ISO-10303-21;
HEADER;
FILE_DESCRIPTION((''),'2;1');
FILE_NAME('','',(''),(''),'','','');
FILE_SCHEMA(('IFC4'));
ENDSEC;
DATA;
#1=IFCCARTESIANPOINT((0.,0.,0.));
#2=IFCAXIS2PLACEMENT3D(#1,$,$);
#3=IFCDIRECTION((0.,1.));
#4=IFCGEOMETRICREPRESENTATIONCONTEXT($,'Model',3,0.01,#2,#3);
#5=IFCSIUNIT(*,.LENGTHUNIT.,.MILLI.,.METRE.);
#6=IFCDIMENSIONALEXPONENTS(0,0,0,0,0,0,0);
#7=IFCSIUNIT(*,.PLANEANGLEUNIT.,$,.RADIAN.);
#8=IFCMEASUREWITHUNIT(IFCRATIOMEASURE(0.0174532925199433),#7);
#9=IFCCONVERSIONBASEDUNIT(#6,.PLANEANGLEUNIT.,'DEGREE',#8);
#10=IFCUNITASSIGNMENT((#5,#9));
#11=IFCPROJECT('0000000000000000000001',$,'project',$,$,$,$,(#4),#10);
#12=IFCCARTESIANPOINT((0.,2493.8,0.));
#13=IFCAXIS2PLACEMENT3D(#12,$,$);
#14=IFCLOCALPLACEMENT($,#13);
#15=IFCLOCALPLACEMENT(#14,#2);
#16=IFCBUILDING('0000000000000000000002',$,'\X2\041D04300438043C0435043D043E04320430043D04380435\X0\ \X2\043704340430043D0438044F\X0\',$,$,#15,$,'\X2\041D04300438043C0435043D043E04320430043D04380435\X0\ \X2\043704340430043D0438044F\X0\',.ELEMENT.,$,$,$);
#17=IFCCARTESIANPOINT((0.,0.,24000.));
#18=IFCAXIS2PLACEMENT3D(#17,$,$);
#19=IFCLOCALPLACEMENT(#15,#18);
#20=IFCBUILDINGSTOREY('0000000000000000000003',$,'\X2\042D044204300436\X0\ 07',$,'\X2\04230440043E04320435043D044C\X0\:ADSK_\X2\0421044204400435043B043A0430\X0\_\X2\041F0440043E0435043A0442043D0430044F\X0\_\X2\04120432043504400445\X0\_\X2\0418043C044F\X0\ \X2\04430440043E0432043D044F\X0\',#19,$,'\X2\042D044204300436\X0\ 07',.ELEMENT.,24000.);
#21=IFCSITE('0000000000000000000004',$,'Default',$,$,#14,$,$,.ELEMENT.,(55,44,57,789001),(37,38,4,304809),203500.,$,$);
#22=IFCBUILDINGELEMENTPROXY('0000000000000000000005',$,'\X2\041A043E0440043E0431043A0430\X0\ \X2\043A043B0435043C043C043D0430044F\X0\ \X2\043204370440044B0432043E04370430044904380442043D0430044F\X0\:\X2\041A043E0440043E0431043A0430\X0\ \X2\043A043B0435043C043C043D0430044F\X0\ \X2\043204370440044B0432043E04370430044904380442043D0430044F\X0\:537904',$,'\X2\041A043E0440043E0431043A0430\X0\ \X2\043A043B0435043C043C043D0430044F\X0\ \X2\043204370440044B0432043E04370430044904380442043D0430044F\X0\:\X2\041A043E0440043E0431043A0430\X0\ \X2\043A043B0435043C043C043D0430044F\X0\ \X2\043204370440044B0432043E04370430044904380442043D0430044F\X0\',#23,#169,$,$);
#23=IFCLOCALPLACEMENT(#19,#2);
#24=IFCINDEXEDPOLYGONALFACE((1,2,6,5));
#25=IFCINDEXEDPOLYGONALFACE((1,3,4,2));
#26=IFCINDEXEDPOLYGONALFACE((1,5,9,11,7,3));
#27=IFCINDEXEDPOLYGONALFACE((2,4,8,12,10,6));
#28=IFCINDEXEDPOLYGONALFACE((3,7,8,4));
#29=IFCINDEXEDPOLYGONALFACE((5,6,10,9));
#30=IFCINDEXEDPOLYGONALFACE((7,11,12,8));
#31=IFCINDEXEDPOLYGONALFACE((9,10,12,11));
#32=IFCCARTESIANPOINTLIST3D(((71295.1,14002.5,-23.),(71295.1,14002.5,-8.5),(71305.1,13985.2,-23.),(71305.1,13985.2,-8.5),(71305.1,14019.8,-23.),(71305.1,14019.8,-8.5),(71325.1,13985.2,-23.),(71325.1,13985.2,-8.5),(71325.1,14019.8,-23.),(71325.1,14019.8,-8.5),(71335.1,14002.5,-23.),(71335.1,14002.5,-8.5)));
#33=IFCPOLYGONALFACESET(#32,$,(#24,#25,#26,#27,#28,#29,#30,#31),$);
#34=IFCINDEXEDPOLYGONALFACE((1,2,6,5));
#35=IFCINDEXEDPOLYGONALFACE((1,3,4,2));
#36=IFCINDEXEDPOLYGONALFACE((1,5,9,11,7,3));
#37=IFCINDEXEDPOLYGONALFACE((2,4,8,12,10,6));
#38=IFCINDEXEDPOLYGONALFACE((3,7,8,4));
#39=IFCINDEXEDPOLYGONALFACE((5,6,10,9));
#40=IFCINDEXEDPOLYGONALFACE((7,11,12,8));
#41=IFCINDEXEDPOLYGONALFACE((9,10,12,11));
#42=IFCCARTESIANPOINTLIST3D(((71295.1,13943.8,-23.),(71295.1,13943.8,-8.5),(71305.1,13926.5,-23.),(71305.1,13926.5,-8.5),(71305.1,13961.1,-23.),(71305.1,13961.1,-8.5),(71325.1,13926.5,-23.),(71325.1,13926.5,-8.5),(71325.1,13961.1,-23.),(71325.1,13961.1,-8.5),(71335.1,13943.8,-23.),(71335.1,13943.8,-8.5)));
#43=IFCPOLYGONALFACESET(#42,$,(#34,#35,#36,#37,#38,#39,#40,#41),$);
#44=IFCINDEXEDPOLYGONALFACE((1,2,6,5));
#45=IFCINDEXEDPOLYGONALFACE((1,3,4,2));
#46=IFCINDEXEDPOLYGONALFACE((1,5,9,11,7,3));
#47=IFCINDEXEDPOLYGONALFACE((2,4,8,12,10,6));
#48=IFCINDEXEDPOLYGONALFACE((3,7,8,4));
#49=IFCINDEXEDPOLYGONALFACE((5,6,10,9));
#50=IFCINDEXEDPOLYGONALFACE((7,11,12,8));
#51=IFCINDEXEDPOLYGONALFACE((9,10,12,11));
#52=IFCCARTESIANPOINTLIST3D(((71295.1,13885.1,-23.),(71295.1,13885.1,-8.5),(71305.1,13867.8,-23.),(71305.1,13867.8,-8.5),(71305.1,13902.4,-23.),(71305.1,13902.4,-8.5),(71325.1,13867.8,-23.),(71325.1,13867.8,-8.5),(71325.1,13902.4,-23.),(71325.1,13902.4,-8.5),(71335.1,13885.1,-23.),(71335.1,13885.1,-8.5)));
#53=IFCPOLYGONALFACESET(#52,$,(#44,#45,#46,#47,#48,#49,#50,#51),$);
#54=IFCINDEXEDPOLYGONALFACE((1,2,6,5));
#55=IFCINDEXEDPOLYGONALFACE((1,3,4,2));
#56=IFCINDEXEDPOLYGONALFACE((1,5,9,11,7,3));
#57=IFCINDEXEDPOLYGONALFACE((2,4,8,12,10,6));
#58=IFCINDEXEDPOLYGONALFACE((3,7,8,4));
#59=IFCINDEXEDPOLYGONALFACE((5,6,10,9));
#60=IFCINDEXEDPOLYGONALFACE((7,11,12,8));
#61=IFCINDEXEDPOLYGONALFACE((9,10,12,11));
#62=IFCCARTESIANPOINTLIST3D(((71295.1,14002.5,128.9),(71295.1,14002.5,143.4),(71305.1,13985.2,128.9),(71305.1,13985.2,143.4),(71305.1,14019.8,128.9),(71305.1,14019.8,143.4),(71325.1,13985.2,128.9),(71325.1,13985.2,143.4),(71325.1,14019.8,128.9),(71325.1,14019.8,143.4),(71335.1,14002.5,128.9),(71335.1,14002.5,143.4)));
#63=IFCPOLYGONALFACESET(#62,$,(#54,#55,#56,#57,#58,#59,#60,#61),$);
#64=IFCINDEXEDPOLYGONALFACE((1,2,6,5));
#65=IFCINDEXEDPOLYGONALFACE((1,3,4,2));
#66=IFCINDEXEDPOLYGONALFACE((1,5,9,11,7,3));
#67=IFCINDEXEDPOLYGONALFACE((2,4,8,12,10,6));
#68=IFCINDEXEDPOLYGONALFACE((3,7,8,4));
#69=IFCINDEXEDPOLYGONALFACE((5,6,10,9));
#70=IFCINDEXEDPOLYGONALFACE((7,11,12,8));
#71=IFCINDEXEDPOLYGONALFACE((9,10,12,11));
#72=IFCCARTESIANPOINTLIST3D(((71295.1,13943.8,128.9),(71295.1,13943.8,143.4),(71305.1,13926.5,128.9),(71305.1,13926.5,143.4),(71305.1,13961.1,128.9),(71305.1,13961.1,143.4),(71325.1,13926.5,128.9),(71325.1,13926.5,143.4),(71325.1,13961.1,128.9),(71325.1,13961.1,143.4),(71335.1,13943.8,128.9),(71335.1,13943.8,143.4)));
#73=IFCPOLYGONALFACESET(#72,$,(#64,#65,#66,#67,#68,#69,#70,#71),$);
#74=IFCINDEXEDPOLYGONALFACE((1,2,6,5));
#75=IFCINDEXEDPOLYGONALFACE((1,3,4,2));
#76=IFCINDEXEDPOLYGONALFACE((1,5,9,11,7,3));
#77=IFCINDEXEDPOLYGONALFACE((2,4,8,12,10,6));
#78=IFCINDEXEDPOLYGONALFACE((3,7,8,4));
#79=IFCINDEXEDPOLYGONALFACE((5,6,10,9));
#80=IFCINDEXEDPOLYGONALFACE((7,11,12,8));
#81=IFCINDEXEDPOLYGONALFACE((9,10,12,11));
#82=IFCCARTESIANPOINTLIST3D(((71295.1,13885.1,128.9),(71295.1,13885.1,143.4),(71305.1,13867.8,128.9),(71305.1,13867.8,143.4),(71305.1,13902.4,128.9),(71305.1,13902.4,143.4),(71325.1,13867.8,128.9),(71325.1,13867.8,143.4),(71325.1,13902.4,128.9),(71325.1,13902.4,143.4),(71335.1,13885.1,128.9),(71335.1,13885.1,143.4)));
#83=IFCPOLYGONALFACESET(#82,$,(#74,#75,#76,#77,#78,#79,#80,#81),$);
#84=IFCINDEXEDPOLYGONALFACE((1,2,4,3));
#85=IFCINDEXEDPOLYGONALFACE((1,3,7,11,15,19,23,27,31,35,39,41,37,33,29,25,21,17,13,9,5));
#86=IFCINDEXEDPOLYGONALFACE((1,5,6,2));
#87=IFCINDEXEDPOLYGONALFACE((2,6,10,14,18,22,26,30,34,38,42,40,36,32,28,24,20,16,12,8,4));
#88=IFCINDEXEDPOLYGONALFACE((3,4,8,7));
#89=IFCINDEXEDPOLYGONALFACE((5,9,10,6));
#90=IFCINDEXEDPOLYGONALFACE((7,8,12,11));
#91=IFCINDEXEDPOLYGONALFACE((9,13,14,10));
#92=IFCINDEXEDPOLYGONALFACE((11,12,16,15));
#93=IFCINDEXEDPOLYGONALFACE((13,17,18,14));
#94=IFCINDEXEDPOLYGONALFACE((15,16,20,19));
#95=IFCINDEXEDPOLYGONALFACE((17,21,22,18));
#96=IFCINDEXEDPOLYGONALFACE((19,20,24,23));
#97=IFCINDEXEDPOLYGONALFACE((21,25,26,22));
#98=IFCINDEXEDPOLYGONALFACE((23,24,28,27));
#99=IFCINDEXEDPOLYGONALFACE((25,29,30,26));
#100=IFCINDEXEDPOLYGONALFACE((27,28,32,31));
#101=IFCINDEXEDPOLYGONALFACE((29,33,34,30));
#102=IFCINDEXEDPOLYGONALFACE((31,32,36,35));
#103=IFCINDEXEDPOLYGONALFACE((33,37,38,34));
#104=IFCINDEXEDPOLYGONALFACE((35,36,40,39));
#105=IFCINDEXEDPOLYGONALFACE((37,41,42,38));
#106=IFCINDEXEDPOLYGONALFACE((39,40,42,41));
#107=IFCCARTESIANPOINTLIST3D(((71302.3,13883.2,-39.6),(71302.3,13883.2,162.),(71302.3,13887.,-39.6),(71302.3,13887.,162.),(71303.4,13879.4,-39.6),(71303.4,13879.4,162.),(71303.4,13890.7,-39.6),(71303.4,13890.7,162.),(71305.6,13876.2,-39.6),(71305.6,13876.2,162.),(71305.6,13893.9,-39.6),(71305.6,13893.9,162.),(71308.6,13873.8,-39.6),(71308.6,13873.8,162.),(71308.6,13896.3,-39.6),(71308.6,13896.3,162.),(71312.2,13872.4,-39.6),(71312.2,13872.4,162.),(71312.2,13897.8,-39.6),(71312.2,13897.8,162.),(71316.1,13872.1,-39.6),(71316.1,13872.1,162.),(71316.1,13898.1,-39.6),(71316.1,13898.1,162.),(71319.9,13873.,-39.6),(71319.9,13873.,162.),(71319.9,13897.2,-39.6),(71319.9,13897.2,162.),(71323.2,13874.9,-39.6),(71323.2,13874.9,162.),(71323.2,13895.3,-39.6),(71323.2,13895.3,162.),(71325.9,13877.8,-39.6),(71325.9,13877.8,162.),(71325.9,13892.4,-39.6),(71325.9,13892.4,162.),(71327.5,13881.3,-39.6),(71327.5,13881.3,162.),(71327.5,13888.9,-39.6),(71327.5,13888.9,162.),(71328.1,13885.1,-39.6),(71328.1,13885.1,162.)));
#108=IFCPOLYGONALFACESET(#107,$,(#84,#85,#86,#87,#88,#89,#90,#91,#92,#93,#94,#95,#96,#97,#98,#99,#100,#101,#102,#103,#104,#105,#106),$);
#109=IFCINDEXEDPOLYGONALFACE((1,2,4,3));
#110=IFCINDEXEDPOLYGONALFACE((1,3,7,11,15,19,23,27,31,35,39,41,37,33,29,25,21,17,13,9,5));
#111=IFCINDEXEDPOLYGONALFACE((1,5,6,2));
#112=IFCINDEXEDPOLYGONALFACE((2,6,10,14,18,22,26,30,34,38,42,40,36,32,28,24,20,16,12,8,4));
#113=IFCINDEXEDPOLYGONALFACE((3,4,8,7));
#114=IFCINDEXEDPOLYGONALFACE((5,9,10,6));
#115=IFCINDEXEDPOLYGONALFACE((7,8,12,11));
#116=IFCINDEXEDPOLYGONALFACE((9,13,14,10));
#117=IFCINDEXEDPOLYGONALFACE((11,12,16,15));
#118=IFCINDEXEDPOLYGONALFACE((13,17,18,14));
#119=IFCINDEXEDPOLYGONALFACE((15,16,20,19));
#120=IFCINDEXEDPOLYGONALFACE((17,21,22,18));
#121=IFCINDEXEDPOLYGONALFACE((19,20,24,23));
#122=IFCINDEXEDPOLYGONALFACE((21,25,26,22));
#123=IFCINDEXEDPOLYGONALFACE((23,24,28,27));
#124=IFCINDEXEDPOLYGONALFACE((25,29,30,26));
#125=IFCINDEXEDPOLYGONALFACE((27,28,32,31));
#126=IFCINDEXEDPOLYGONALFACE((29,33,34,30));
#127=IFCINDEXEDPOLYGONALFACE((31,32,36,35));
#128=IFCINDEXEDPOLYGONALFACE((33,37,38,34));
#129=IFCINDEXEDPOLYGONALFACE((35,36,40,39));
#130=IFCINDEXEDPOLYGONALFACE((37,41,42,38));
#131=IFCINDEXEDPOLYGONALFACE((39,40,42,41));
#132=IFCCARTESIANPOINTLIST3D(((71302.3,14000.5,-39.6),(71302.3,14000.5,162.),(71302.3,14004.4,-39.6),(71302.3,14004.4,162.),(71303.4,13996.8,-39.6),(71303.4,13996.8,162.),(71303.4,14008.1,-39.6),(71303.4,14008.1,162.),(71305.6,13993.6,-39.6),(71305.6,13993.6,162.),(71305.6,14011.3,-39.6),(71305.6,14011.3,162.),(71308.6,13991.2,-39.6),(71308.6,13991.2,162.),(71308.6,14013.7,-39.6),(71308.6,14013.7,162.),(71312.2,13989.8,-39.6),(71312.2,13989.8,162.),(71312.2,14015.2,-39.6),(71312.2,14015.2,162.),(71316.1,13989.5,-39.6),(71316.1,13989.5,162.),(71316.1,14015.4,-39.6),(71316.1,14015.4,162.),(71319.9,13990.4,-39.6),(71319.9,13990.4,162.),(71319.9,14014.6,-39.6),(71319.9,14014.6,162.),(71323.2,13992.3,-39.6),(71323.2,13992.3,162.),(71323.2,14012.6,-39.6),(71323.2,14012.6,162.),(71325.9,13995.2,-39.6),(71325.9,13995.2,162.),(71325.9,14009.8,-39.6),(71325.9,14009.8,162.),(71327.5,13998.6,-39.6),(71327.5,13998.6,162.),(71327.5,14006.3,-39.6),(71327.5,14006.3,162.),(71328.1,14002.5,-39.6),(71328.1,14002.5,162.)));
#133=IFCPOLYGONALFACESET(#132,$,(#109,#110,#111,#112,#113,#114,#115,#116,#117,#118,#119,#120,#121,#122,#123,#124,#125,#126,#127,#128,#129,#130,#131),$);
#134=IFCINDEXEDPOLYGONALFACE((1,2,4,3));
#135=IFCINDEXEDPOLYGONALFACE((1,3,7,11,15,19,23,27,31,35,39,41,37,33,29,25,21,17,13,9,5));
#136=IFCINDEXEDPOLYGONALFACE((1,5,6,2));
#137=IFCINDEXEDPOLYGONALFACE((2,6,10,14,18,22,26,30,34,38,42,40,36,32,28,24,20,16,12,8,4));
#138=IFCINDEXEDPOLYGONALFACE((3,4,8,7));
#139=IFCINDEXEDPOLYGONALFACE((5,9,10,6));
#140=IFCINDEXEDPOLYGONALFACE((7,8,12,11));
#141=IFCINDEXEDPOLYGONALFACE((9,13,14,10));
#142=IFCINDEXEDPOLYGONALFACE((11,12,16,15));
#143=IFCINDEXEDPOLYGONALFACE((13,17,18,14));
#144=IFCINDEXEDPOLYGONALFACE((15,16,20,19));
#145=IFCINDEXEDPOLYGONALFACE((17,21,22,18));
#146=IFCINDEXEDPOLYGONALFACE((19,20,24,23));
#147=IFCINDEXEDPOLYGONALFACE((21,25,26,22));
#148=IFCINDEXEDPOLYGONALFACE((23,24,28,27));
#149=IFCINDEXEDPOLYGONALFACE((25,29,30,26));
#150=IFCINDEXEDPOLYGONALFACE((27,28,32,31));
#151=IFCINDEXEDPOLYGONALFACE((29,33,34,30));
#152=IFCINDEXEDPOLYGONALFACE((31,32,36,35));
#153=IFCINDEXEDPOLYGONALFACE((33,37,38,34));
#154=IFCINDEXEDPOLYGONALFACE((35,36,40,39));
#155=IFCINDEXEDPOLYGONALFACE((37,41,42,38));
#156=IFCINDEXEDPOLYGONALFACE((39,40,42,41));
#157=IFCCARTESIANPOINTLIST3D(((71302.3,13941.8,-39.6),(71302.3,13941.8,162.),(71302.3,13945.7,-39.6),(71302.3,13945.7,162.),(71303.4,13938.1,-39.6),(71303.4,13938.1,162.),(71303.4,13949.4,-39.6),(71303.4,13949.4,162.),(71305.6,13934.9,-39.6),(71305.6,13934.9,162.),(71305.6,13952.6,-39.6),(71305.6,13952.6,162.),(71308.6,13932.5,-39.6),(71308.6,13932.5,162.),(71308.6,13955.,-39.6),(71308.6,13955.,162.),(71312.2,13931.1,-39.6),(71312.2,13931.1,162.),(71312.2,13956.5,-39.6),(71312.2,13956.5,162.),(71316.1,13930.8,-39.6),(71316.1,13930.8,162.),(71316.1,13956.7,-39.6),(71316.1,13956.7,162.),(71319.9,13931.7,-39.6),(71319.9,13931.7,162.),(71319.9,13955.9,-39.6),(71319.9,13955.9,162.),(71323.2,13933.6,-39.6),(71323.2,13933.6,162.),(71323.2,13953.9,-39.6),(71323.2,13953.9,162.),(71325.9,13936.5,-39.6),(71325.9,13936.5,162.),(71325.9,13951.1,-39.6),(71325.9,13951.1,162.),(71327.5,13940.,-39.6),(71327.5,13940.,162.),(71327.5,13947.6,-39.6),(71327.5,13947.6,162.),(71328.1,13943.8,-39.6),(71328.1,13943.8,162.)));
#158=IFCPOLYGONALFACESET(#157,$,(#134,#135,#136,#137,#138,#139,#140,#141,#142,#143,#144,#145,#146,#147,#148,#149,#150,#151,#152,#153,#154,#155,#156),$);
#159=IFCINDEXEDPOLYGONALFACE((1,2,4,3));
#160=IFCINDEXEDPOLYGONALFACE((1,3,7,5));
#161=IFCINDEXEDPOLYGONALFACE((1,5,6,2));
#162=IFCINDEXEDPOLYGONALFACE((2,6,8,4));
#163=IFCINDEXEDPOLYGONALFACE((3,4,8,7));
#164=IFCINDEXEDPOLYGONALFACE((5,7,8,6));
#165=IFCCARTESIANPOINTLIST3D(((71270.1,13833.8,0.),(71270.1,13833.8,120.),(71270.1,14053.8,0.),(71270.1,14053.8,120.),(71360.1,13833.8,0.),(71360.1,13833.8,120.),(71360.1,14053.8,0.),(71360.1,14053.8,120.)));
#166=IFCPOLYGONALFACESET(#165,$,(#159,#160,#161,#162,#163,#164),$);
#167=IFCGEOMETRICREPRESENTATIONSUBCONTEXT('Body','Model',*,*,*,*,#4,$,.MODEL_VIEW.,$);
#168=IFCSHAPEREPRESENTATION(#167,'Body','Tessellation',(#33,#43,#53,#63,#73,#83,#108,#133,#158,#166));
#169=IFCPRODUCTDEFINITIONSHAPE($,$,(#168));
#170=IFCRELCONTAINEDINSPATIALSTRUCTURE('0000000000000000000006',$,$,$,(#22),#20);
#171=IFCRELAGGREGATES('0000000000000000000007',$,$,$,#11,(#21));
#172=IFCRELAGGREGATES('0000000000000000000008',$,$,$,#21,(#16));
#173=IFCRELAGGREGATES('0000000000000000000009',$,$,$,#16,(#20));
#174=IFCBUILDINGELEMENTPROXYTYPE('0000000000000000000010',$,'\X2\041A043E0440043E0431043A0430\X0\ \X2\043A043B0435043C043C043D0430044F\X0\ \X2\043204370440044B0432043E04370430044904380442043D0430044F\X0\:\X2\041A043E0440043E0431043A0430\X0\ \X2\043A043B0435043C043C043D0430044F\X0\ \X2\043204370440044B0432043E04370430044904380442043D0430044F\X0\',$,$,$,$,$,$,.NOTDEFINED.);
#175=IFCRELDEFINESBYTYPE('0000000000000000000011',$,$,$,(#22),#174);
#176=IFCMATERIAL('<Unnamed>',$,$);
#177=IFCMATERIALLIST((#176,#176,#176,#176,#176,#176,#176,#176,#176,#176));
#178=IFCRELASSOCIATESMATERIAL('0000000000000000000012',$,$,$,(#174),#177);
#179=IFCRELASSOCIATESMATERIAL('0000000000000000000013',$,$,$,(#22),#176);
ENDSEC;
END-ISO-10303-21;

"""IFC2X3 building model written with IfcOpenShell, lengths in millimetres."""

from ifc_helpers import new_model, entity, si_unit, converted_unit, direction, frame, frame_2d, origin, place, context, subcontext, project, spatial, polyline, rectangle, circle, outline, extrude, source, transform, mapped, material, material_list, type_object, type_shapes, element, save


model = new_model("IFC2X3")

# Units and contexts
model_context = context("Model", 3, precision=0.01, world=origin(), true_north=direction((0.0, 1.0)))
body_context = subcontext(model_context, "Body", "Model", "MODEL_VIEW")
ifc_project = project(units=[si_unit("LENGTHUNIT", "METRE", prefix="MILLI"), converted_unit("PLANEANGLEUNIT", "DEGREE", entity("IfcRatioMeasure", 0.0174532925199433), si_unit("PLANEANGLEUNIT", "RADIAN"), dimensions=[0, 0, 0, 0, 0, 0, 0])], contexts=[model_context])

# Site, building, storey
site_placement = place(None, frame((0.0, 2493.8, 0.0)))
site = spatial("IfcSite", under=ifc_project, at=site_placement, Name="Default", CompositionType="ELEMENT", RefLatitude=(55, 44, 57, 789001), RefLongitude=(37, 38, 4, 304809), RefElevation=203500.0)
building_placement = place(site_placement, origin())
building = spatial("IfcBuilding", under=site, at=building_placement, Name="Наименование здания", LongName="Наименование здания", CompositionType="ELEMENT")
storey_placement = place(building_placement, frame((0.0, 0.0, 24000.0)))
storey = spatial("IfcBuildingStorey", under=building, at=storey_placement, Name="Этаж 07", ObjectType="Уровень:ADSK_Стрелка_Проектная_Вверх_Имя уровня", LongName="Этаж 07", CompositionType="ELEMENT", Elevation=24000.0)

# Building element proxy
ifc_material = material(Name="<Unnamed>")
ifc_material_list = material_list([ifc_material, ifc_material, ifc_material, ifc_material, ifc_material, ifc_material, ifc_material, ifc_material, ifc_material, ifc_material])
building_element_proxy_type = type_object("IfcBuildingElementProxyType", Name="Коробка клеммная взрывозащитная:Коробка клеммная взрывозащитная", PredefinedType="NOTDEFINED", material=ifc_material_list)
shared_shape = source(origin(), body_context, "Body", "SweptSolid", [
    extrude(outline(polyline([(-10.0, -17.3), (10.0, -17.3), (20.0, 0.0), (10.0, 17.3), (-10.0, 17.3), (-20.0, 0.0), (-10.0, -17.3)])), frame((0.0, 58.7, -23.0), z_axis=(0.0, 0.0, 1.0), x_axis=(-1.0, 0.0, 0.0)), (0.0, 0.0, 1.0), 14.4),
    extrude(outline(polyline([(-10.0, -17.3), (10.0, -17.3), (20.0, 0.0), (10.0, 17.3), (-10.0, 17.3), (-20.0, 0.0), (-10.0, -17.3)])), frame((0.0, 0.0, -23.0), z_axis=(0.0, 0.0, 1.0), x_axis=(-1.0, 0.0, 0.0)), (0.0, 0.0, 1.0), 14.4),
    extrude(outline(polyline([(-10.0, -17.3), (10.0, -17.3), (20.0, 0.0), (10.0, 17.3), (-10.0, 17.3), (-20.0, 0.0), (-10.0, -17.3)])), frame((0.0, -58.7, -23.0), z_axis=(0.0, 0.0, 1.0), x_axis=(-1.0, 0.0, 0.0)), (0.0, 0.0, 1.0), 14.4),
    extrude(outline(polyline([(-10.0, -17.3), (10.0, -17.3), (20.0, 0.0), (10.0, 17.3), (-10.0, 17.3), (-20.0, 0.0), (-10.0, -17.3)])), frame((0.0, 58.7, 128.9), z_axis=(0.0, 0.0, 1.0), x_axis=(-1.0, 0.0, 0.0)), (0.0, 0.0, 1.0), 14.4),
    extrude(outline(polyline([(-10.0, -17.3), (10.0, -17.3), (20.0, 0.0), (10.0, 17.3), (-10.0, 17.3), (-20.0, 0.0), (-10.0, -17.3)])), frame((0.0, 0.0, 128.9), z_axis=(0.0, 0.0, 1.0), x_axis=(-1.0, 0.0, 0.0)), (0.0, 0.0, 1.0), 14.4),
    extrude(outline(polyline([(-10.0, -17.3), (10.0, -17.3), (20.0, 0.0), (10.0, 17.3), (-10.0, 17.3), (-20.0, 0.0), (-10.0, -17.3)])), frame((0.0, -58.7, 128.9), z_axis=(0.0, 0.0, 1.0), x_axis=(-1.0, 0.0, 0.0)), (0.0, 0.0, 1.0), 14.4),
    extrude(circle(Radius=13.0, at=frame_2d((0.0, 0.0), x_axis=(1.0, 0.0))), frame((0.0, -58.7, -39.6)), (0.0, 0.0, 1.0), 201.6),
    extrude(circle(Radius=13.0, at=frame_2d((0.0, 0.0), x_axis=(1.0, 0.0))), frame((0.0, 58.7, -39.6)), (0.0, 0.0, 1.0), 201.6),
    extrude(circle(Radius=13.0, at=frame_2d((0.0, 0.0), x_axis=(1.0, 0.0))), frame((0.0, 0.0, -39.6)), (0.0, 0.0, 1.0), 201.6),
    extrude(rectangle(XDim=220.0, YDim=90.0, at=frame_2d((0.0, 0.0), x_axis=(1.0, 0.0))), frame((0.0, 0.0, 0.0), z_axis=(0.0, 0.0, 1.0), x_axis=(0.0, -1.0, 0.0)), (0.0, 0.0, 1.0), 120.0),
])
type_shapes(building_element_proxy_type, [shared_shape])
for number, where, name in (
    (1, (71315.1, 13943.8, 0.0), "Коробка клеммная взрывозащитная:Коробка клеммная взрывозащитная:537904"),
):
    element("IfcBuildingElementProxy", number, at=place(storey_placement, frame(where)), inside=storey, type_object=building_element_proxy_type, material=ifc_material, Name=name, ObjectType="Коробка клеммная взрывозащитная:Коробка клеммная взрывозащитная", context=body_context, shape_type="MappedRepresentation", body=[
        mapped(shared_shape, transform((0.0, 0.0, 0.0), scale=1.0)),
    ])

save(model, "model.ifc")
